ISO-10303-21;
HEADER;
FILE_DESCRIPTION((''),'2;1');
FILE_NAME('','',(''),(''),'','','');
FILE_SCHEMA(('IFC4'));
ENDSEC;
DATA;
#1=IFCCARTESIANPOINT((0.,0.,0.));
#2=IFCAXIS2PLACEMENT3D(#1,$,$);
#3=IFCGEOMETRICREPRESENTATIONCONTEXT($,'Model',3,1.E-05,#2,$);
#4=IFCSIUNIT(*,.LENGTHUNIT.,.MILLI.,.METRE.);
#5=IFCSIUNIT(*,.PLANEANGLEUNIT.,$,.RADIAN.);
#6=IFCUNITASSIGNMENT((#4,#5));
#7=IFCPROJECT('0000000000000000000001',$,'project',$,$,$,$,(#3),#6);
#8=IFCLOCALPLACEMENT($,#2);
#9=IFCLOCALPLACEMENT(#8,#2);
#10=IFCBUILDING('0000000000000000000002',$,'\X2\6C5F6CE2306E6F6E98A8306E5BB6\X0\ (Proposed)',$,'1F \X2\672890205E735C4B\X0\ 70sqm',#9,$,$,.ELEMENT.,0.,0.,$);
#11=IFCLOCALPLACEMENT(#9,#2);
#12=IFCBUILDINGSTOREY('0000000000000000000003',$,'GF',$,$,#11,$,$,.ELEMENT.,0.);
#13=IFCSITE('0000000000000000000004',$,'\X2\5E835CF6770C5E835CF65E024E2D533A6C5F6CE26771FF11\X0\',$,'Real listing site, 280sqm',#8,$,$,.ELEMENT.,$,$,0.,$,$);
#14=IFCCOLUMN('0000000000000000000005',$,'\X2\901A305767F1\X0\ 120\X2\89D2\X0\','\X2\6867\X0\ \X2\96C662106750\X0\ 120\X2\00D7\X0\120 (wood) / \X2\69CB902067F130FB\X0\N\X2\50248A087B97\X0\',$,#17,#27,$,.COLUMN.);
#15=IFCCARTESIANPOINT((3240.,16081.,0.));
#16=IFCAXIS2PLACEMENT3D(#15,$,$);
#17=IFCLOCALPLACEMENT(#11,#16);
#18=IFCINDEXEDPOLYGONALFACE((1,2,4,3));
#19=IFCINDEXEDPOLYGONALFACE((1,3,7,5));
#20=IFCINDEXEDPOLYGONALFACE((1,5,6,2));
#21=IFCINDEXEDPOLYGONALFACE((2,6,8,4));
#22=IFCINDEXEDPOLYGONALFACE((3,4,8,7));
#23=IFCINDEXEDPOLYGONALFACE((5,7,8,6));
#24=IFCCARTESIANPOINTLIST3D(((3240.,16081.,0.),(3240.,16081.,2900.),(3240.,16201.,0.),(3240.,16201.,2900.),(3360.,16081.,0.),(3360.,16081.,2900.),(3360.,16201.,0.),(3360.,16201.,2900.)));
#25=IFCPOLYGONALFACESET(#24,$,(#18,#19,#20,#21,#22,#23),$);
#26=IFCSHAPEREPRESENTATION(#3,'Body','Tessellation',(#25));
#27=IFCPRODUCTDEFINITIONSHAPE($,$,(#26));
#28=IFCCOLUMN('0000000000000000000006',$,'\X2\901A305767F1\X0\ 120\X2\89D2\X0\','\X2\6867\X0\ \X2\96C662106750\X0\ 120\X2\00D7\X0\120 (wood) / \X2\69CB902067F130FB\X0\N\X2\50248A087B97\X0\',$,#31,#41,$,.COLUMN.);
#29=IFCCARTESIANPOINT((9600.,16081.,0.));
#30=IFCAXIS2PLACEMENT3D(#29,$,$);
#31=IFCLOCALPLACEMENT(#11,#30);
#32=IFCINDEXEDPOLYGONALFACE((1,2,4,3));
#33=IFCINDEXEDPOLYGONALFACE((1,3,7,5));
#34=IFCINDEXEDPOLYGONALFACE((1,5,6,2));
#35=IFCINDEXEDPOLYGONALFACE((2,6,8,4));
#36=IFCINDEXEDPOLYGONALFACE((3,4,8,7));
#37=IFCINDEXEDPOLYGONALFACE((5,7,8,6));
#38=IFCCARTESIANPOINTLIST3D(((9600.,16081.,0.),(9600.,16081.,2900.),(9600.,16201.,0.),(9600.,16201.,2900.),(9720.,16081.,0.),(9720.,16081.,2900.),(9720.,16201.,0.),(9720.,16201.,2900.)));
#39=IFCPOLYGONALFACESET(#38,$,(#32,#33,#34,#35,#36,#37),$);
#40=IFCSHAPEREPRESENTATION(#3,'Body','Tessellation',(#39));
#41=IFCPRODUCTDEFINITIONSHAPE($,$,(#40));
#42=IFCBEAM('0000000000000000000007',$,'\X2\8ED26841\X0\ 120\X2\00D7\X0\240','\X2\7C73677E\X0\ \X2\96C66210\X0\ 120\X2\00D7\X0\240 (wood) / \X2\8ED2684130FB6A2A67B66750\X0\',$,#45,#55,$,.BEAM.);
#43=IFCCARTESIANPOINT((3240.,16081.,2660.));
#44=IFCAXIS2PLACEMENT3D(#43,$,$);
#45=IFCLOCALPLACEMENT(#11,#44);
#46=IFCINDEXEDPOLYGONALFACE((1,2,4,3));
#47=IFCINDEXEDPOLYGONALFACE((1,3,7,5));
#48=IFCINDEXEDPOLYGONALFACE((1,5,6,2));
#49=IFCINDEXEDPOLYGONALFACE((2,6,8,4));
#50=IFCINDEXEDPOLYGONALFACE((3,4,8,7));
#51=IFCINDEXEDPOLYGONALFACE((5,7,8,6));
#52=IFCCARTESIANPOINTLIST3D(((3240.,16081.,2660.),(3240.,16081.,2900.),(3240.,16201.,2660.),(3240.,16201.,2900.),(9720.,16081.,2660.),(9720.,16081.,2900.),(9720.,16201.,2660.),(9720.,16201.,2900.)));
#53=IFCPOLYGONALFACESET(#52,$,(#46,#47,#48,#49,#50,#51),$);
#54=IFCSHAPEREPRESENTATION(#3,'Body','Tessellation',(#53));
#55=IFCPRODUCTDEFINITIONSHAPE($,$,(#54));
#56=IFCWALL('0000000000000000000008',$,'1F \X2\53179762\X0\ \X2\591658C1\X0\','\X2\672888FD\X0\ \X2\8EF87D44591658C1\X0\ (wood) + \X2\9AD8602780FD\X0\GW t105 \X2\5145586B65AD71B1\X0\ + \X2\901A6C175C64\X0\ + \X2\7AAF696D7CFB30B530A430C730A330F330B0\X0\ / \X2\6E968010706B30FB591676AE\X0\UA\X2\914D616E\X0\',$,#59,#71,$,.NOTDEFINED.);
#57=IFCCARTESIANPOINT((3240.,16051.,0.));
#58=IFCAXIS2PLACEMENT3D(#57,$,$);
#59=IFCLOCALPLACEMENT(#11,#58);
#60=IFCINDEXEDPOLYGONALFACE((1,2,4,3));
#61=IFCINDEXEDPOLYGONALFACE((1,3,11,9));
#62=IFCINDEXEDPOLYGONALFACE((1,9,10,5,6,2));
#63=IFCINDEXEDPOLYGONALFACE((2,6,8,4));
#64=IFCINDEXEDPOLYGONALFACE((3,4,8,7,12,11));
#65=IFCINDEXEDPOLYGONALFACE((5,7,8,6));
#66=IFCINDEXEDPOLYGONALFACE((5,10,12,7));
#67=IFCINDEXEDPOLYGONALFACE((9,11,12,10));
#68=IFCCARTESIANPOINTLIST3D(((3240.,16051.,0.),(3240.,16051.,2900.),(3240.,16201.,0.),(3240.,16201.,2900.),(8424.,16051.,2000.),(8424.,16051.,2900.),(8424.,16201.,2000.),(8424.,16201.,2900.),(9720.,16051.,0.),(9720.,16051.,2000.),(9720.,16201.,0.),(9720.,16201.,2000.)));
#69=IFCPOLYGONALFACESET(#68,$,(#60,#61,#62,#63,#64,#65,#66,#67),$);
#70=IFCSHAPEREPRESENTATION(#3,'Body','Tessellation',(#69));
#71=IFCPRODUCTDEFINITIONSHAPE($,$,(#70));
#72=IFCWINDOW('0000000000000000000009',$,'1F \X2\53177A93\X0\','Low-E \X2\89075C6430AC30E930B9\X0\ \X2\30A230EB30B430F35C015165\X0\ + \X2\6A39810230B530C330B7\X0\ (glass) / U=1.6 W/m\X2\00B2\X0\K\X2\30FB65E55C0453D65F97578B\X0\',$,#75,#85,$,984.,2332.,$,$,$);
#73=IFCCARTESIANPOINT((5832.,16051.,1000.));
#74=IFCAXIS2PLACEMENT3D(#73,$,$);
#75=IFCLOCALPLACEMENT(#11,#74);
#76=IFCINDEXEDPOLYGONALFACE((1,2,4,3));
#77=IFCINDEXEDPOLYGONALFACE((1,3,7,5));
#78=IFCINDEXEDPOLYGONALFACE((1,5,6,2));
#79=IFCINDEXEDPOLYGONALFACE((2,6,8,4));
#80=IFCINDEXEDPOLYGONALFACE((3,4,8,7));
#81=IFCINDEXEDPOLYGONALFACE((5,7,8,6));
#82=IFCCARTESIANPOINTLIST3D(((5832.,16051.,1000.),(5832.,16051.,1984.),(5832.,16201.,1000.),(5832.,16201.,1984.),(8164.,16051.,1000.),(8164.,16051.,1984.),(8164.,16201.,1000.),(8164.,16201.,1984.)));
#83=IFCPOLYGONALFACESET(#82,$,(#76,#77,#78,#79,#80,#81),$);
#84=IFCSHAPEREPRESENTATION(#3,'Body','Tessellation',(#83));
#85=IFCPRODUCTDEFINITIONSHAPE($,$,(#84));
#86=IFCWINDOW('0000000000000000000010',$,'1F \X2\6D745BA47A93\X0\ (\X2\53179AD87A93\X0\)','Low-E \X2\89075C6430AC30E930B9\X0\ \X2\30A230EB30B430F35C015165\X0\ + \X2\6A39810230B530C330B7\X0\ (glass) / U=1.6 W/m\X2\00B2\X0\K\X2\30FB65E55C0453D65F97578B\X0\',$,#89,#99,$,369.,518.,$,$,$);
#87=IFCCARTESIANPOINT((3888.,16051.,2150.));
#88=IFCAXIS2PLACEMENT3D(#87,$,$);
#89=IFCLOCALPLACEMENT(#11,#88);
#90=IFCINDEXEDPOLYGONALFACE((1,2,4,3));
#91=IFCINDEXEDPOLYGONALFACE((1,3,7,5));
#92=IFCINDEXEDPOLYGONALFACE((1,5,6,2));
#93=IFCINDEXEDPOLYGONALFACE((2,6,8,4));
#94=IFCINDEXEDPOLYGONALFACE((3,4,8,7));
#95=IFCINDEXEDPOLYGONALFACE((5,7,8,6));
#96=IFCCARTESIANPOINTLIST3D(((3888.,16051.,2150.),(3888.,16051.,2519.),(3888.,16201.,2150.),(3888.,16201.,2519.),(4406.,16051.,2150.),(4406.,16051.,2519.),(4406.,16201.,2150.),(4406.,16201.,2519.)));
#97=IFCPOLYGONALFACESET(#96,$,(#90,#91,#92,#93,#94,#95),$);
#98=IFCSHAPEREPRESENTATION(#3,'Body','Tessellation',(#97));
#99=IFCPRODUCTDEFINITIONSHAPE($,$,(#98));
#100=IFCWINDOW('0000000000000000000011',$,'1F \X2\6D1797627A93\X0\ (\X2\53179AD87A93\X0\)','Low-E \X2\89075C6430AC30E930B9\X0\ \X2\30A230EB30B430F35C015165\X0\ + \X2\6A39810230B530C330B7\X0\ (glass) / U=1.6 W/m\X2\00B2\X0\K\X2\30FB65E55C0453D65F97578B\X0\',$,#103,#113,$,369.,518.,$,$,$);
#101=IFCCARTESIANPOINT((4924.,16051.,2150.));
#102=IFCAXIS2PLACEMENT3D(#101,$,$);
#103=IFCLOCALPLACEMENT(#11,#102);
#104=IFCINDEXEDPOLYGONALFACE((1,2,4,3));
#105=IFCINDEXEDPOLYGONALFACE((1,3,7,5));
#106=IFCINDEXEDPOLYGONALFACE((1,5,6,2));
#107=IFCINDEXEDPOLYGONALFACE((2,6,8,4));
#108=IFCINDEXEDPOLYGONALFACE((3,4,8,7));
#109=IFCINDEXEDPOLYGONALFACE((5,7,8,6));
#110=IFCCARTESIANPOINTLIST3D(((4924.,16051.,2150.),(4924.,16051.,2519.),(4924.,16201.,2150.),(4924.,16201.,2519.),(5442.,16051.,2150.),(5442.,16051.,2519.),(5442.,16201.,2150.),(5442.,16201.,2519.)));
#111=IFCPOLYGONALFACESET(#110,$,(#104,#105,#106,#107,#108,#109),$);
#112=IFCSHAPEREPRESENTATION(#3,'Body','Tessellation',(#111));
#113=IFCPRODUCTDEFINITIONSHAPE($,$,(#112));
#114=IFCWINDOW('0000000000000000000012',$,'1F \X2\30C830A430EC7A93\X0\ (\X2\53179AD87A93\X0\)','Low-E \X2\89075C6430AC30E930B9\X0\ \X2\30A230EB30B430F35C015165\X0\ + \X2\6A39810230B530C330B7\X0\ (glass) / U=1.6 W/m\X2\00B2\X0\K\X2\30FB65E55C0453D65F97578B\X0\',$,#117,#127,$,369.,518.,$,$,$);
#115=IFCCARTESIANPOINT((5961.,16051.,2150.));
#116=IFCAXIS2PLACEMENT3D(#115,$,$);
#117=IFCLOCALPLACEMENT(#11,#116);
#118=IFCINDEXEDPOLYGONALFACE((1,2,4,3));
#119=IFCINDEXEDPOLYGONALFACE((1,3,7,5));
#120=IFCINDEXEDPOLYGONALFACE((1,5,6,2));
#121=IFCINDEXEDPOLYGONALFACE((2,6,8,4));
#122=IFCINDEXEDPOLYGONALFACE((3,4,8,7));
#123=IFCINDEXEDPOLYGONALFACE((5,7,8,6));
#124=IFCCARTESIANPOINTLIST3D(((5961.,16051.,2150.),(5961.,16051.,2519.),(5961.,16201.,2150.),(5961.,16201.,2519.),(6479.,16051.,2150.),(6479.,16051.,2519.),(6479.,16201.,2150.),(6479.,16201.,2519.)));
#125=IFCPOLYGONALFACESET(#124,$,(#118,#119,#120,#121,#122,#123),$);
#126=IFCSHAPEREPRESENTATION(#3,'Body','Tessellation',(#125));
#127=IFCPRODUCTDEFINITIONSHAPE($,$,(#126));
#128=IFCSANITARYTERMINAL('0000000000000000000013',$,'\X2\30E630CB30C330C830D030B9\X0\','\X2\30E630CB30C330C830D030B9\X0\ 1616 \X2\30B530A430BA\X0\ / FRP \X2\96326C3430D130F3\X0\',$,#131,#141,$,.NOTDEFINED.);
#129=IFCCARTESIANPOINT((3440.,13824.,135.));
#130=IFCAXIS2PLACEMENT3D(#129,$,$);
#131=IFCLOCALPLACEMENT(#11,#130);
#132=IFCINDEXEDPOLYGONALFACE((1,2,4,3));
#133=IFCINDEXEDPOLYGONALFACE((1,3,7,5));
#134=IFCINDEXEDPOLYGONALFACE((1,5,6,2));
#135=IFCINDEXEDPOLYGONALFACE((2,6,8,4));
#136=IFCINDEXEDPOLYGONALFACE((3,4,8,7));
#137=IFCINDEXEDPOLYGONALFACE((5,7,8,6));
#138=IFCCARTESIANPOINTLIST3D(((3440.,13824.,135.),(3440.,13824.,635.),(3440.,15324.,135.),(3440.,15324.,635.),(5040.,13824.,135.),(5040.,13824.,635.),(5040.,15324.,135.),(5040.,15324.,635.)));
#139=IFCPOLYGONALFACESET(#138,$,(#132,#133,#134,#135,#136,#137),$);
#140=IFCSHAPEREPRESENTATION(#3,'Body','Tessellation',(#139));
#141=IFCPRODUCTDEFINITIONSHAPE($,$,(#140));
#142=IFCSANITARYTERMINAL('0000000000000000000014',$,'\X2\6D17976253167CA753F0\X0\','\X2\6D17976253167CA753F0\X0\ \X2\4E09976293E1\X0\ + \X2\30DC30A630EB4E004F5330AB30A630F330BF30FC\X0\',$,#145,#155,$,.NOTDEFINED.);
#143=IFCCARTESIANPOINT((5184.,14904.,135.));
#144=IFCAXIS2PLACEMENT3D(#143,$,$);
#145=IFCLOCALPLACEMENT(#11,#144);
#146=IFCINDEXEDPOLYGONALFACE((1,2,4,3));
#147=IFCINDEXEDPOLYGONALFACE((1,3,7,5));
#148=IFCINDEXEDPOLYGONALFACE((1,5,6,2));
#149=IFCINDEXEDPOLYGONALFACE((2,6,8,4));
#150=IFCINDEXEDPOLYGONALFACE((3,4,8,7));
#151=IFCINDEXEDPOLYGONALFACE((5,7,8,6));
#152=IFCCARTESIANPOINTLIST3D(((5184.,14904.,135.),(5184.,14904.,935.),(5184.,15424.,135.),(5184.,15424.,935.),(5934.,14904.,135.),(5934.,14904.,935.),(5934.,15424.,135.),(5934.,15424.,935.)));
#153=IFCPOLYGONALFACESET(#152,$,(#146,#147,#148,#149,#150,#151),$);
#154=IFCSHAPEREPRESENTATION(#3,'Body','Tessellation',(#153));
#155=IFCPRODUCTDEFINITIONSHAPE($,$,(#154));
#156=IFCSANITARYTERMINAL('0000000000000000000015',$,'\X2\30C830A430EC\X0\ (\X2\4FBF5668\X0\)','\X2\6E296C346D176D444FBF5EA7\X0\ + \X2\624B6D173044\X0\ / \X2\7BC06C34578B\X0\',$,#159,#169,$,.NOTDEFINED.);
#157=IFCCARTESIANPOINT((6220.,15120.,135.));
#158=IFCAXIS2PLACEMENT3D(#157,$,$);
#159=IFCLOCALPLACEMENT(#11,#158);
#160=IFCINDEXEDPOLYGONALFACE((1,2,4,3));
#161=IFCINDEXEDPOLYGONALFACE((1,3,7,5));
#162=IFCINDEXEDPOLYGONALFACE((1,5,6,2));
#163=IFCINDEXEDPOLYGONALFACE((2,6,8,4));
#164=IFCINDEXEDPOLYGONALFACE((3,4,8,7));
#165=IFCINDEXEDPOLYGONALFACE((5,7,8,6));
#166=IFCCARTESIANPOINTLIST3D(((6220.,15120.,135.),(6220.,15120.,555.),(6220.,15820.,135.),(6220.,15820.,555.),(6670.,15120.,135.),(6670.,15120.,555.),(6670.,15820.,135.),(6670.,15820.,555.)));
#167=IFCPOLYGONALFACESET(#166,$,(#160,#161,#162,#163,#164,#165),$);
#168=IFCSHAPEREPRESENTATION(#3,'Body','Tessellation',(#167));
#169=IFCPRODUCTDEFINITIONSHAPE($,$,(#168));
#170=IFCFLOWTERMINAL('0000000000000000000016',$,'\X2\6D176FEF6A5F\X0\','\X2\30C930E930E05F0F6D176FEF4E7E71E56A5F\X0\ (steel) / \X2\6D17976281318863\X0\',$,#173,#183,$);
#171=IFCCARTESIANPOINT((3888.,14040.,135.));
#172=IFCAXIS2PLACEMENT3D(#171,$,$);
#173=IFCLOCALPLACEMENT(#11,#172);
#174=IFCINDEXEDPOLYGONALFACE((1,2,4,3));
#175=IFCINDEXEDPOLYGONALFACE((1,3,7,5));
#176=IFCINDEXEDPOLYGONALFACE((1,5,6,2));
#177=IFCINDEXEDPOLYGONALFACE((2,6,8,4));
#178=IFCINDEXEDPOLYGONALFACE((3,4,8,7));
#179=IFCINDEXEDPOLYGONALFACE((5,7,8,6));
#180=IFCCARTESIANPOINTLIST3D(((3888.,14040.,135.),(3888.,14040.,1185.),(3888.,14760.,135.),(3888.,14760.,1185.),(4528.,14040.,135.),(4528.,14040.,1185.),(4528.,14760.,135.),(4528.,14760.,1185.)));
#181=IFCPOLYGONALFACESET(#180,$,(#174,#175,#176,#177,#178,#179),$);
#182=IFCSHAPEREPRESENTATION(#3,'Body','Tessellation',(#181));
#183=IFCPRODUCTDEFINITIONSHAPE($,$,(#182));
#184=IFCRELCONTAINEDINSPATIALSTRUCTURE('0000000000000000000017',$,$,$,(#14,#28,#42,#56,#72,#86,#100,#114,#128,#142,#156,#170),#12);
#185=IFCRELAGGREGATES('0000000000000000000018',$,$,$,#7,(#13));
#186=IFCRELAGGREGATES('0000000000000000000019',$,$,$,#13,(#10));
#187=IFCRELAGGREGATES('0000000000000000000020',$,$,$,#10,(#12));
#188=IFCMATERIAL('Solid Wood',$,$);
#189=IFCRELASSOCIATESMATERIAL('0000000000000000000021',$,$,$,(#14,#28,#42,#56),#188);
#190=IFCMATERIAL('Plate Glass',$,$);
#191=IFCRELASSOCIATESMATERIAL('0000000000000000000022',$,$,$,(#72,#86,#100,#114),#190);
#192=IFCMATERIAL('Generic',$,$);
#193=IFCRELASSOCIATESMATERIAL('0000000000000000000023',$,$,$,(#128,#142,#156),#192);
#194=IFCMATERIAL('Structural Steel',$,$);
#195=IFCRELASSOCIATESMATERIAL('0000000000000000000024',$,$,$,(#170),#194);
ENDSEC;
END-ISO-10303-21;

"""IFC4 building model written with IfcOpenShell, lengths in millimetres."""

from ifc_helpers import new_model, si_unit, frame, frame_2d, origin, place, context, project, spatial, rectangle, extrude, material, element, fill, save


model = new_model("IFC4")

# Units and contexts
model_context = context("Model", 3, precision=1e-05, world=origin())
ifc_project = project(units=[si_unit("LENGTHUNIT", "METRE", prefix="MILLI"), si_unit("PLANEANGLEUNIT", "RADIAN")], contexts=[model_context])

# Site, building, storey
site_placement = place(None, origin())
site = spatial("IfcSite", under=ifc_project, at=site_placement, Name="広島県広島市中区江波東１", ObjectType="Real listing site, 280sqm", CompositionType="ELEMENT", RefElevation=0.0)
building_placement = place(site_placement, origin())
building = spatial("IfcBuilding", under=site, at=building_placement, Name="江波の潮風の家 (Proposed)", ObjectType="1F 木造平屋 70sqm", CompositionType="ELEMENT", ElevationOfRefHeight=0.0, ElevationOfTerrain=0.0)
storey_placement = place(building_placement, origin())
storey = spatial("IfcBuildingStorey", under=building, at=storey_placement, Name="GF", CompositionType="ELEMENT", Elevation=0.0)

# Columns
ifc_material_1 = material(Name="Solid Wood")
column_1_placement = place(storey_placement, frame((3240.0, 16081.0, 0.0)))
element("IfcColumn", 1, at=column_1_placement, inside=storey, material=ifc_material_1, Name="通し柱 120角", Description="桧 集成材 120×120 (wood) / 構造柱・N値計算", PredefinedType="COLUMN", context=model_context, shape_type="SweptSolid", body=[
    extrude(rectangle(XDim=120.0, YDim=120.0, at=frame_2d((60.0, 60.0))), frame((3240.0, 16081.0, 0.0)), (0.0, 0.0, 1.0), 2900.0),
])
column_2_placement = place(storey_placement, frame((9600.0, 16081.0, 0.0)))
element("IfcColumn", 2, at=column_2_placement, inside=storey, material=ifc_material_1, Name="通し柱 120角", Description="桧 集成材 120×120 (wood) / 構造柱・N値計算", PredefinedType="COLUMN", context=model_context, shape_type="SweptSolid", body=[
    extrude(rectangle(XDim=120.0, YDim=120.0, at=frame_2d((60.0, 60.0))), frame((9600.0, 16081.0, 0.0)), (0.0, 0.0, 1.0), 2900.0),
])

# Beam
beam_1_placement = place(storey_placement, frame((3240.0, 16081.0, 2660.0)))
element("IfcBeam", 3, at=beam_1_placement, inside=storey, material=ifc_material_1, Name="軒桁 120×240", Description="米松 集成 120×240 (wood) / 軒桁・横架材", PredefinedType="BEAM", context=model_context, shape_type="SweptSolid", body=[
    extrude(rectangle(XDim=6480.0, YDim=120.0, at=frame_2d((3240.0, 60.0))), frame((3240.0, 16081.0, 2660.0)), (0.0, 0.0, 1.0), 240.0),
])

# Wall, openings, windows
wall_placement = place(storey_placement, frame((3240.0, 16051.0, 0.0)))
wall = element("IfcWall", 4, at=wall_placement, inside=storey, material=ifc_material_1, Name="1F 北面 外壁", Description="木製 軸組外壁 (wood) + 高性能GW t105 充填断熱 + 通気層 + 窯業系サイディング / 準耐火・外皮UA配慮", PredefinedType="NOTDEFINED", context=model_context, shape_type="SweptSolid", body=[
    extrude(rectangle(XDim=6480.0, YDim=150.0, at=frame_2d((3240.0, 75.0))), frame((3240.0, 16051.0, 0.0)), (0.0, 0.0, 1.0), 2900.0),
])
opening_1_placement = place(storey_placement, frame((5832.0, 16051.0, 1000.0)))
opening_1 = element("IfcOpeningElement", 5, at=opening_1_placement, cuts=wall, PredefinedType="NOTDEFINED", context=model_context, shape_type="SweptSolid", body=[
    extrude(rectangle(XDim=2332.0, YDim=150.0, at=frame_2d((1166.0, 75.0))), frame((5832.0, 16051.0, 1000.0)), (0.0, 0.0, 1.0), 984.0),
])
opening_2_placement = place(storey_placement, frame((3888.0, 16051.0, 2150.0)))
opening_2 = element("IfcOpeningElement", 6, at=opening_2_placement, cuts=wall, PredefinedType="NOTDEFINED", context=model_context, shape_type="SweptSolid", body=[
    extrude(rectangle(XDim=518.0, YDim=150.0, at=frame_2d((259.0, 75.0))), frame((3888.0, 16051.0, 2150.0)), (0.0, 0.0, 1.0), 369.0),
])
opening_3_placement = place(storey_placement, frame((4924.0, 16051.0, 2150.0)))
opening_3 = element("IfcOpeningElement", 7, at=opening_3_placement, cuts=wall, PredefinedType="NOTDEFINED", context=model_context, shape_type="SweptSolid", body=[
    extrude(rectangle(XDim=518.0, YDim=150.0, at=frame_2d((259.0, 75.0))), frame((4924.0, 16051.0, 2150.0)), (0.0, 0.0, 1.0), 369.0),
])
opening_4_placement = place(storey_placement, frame((5961.0, 16051.0, 2150.0)))
opening_4 = element("IfcOpeningElement", 8, at=opening_4_placement, cuts=wall, PredefinedType="NOTDEFINED", context=model_context, shape_type="SweptSolid", body=[
    extrude(rectangle(XDim=518.0, YDim=150.0, at=frame_2d((259.0, 75.0))), frame((5961.0, 16051.0, 2150.0)), (0.0, 0.0, 1.0), 369.0),
])
ifc_material_2 = material(Name="Plate Glass")
window_1_placement = place(storey_placement, frame((5832.0, 16051.0, 1000.0)))
window_1 = element("IfcWindow", 9, at=window_1_placement, inside=storey, material=ifc_material_2, Name="1F 北窓", Description="Low-E 複層ガラス アルゴン封入 + 樹脂サッシ (glass) / U=1.6 W/m²K・日射取得型", OverallHeight=984.0, OverallWidth=2332.0, context=model_context, shape_type="SweptSolid", body=[
    extrude(rectangle(XDim=2332.0, YDim=150.0, at=frame_2d((1166.0, 75.0))), frame((5832.0, 16051.0, 1000.0)), (0.0, 0.0, 1.0), 984.0),
])
fill(opening_1, window_1)
window_2_placement = place(storey_placement, frame((3888.0, 16051.0, 2150.0)))
window_2 = element("IfcWindow", 10, at=window_2_placement, inside=storey, material=ifc_material_2, Name="1F 浴室窓 (北高窓)", Description="Low-E 複層ガラス アルゴン封入 + 樹脂サッシ (glass) / U=1.6 W/m²K・日射取得型", OverallHeight=369.0, OverallWidth=518.0, context=model_context, shape_type="SweptSolid", body=[
    extrude(rectangle(XDim=518.0, YDim=150.0, at=frame_2d((259.0, 75.0))), frame((3888.0, 16051.0, 2150.0)), (0.0, 0.0, 1.0), 369.0),
])
fill(opening_2, window_2)
window_3_placement = place(storey_placement, frame((4924.0, 16051.0, 2150.0)))
window_3 = element("IfcWindow", 11, at=window_3_placement, inside=storey, material=ifc_material_2, Name="1F 洗面窓 (北高窓)", Description="Low-E 複層ガラス アルゴン封入 + 樹脂サッシ (glass) / U=1.6 W/m²K・日射取得型", OverallHeight=369.0, OverallWidth=518.0, context=model_context, shape_type="SweptSolid", body=[
    extrude(rectangle(XDim=518.0, YDim=150.0, at=frame_2d((259.0, 75.0))), frame((4924.0, 16051.0, 2150.0)), (0.0, 0.0, 1.0), 369.0),
])
fill(opening_3, window_3)
window_4_placement = place(storey_placement, frame((5961.0, 16051.0, 2150.0)))
window_4 = element("IfcWindow", 12, at=window_4_placement, inside=storey, material=ifc_material_2, Name="1F トイレ窓 (北高窓)", Description="Low-E 複層ガラス アルゴン封入 + 樹脂サッシ (glass) / U=1.6 W/m²K・日射取得型", OverallHeight=369.0, OverallWidth=518.0, context=model_context, shape_type="SweptSolid", body=[
    extrude(rectangle(XDim=518.0, YDim=150.0, at=frame_2d((259.0, 75.0))), frame((5961.0, 16051.0, 2150.0)), (0.0, 0.0, 1.0), 369.0),
])
fill(opening_4, window_4)

# Sanitary terminals
ifc_material_3 = material(Name="Generic")
sanitary_terminal_1_placement = place(storey_placement, frame((3440.0, 13824.0, 135.0)))
element("IfcSanitaryTerminal", 13, at=sanitary_terminal_1_placement, inside=storey, material=ifc_material_3, Name="ユニットバス", Description="ユニットバス 1616 サイズ / FRP 防水パン", PredefinedType="NOTDEFINED", context=model_context, shape_type="SweptSolid", body=[
    extrude(rectangle(XDim=1600.0, YDim=1500.0, at=frame_2d((800.0, 750.0))), frame((3440.0, 13824.0, 135.0)), (0.0, 0.0, 1.0), 500.0),
])
sanitary_terminal_2_placement = place(storey_placement, frame((5184.0, 14904.0, 135.0)))
element("IfcSanitaryTerminal", 14, at=sanitary_terminal_2_placement, inside=storey, material=ifc_material_3, Name="洗面化粧台", Description="洗面化粧台 三面鏡 + ボウル一体カウンター", PredefinedType="NOTDEFINED", context=model_context, shape_type="SweptSolid", body=[
    extrude(rectangle(XDim=750.0, YDim=520.0, at=frame_2d((375.0, 260.0))), frame((5184.0, 14904.0, 135.0)), (0.0, 0.0, 1.0), 800.0),
])
sanitary_terminal_3_placement = place(storey_placement, frame((6220.0, 15120.0, 135.0)))
element("IfcSanitaryTerminal", 15, at=sanitary_terminal_3_placement, inside=storey, material=ifc_material_3, Name="トイレ (便器)", Description="温水洗浄便座 + 手洗い / 節水型", PredefinedType="NOTDEFINED", context=model_context, shape_type="SweptSolid", body=[
    extrude(rectangle(XDim=450.0, YDim=700.0, at=frame_2d((225.0, 350.0))), frame((6220.0, 15120.0, 135.0)), (0.0, 0.0, 1.0), 420.0),
])

# Flow terminal
ifc_material_4 = material(Name="Structural Steel")
flow_terminal_placement = place(storey_placement, frame((3888.0, 14040.0, 135.0)))
element("IfcFlowTerminal", 16, at=flow_terminal_placement, inside=storey, material=ifc_material_4, Name="洗濯機", Description="ドラム式洗濯乾燥機 (steel) / 洗面脱衣", context=model_context, shape_type="SweptSolid", body=[
    extrude(rectangle(XDim=640.0, YDim=720.0, at=frame_2d((320.0, 360.0))), frame((3888.0, 14040.0, 135.0)), (0.0, 0.0, 1.0), 1050.0),
])

save(model, "model.ifc")
